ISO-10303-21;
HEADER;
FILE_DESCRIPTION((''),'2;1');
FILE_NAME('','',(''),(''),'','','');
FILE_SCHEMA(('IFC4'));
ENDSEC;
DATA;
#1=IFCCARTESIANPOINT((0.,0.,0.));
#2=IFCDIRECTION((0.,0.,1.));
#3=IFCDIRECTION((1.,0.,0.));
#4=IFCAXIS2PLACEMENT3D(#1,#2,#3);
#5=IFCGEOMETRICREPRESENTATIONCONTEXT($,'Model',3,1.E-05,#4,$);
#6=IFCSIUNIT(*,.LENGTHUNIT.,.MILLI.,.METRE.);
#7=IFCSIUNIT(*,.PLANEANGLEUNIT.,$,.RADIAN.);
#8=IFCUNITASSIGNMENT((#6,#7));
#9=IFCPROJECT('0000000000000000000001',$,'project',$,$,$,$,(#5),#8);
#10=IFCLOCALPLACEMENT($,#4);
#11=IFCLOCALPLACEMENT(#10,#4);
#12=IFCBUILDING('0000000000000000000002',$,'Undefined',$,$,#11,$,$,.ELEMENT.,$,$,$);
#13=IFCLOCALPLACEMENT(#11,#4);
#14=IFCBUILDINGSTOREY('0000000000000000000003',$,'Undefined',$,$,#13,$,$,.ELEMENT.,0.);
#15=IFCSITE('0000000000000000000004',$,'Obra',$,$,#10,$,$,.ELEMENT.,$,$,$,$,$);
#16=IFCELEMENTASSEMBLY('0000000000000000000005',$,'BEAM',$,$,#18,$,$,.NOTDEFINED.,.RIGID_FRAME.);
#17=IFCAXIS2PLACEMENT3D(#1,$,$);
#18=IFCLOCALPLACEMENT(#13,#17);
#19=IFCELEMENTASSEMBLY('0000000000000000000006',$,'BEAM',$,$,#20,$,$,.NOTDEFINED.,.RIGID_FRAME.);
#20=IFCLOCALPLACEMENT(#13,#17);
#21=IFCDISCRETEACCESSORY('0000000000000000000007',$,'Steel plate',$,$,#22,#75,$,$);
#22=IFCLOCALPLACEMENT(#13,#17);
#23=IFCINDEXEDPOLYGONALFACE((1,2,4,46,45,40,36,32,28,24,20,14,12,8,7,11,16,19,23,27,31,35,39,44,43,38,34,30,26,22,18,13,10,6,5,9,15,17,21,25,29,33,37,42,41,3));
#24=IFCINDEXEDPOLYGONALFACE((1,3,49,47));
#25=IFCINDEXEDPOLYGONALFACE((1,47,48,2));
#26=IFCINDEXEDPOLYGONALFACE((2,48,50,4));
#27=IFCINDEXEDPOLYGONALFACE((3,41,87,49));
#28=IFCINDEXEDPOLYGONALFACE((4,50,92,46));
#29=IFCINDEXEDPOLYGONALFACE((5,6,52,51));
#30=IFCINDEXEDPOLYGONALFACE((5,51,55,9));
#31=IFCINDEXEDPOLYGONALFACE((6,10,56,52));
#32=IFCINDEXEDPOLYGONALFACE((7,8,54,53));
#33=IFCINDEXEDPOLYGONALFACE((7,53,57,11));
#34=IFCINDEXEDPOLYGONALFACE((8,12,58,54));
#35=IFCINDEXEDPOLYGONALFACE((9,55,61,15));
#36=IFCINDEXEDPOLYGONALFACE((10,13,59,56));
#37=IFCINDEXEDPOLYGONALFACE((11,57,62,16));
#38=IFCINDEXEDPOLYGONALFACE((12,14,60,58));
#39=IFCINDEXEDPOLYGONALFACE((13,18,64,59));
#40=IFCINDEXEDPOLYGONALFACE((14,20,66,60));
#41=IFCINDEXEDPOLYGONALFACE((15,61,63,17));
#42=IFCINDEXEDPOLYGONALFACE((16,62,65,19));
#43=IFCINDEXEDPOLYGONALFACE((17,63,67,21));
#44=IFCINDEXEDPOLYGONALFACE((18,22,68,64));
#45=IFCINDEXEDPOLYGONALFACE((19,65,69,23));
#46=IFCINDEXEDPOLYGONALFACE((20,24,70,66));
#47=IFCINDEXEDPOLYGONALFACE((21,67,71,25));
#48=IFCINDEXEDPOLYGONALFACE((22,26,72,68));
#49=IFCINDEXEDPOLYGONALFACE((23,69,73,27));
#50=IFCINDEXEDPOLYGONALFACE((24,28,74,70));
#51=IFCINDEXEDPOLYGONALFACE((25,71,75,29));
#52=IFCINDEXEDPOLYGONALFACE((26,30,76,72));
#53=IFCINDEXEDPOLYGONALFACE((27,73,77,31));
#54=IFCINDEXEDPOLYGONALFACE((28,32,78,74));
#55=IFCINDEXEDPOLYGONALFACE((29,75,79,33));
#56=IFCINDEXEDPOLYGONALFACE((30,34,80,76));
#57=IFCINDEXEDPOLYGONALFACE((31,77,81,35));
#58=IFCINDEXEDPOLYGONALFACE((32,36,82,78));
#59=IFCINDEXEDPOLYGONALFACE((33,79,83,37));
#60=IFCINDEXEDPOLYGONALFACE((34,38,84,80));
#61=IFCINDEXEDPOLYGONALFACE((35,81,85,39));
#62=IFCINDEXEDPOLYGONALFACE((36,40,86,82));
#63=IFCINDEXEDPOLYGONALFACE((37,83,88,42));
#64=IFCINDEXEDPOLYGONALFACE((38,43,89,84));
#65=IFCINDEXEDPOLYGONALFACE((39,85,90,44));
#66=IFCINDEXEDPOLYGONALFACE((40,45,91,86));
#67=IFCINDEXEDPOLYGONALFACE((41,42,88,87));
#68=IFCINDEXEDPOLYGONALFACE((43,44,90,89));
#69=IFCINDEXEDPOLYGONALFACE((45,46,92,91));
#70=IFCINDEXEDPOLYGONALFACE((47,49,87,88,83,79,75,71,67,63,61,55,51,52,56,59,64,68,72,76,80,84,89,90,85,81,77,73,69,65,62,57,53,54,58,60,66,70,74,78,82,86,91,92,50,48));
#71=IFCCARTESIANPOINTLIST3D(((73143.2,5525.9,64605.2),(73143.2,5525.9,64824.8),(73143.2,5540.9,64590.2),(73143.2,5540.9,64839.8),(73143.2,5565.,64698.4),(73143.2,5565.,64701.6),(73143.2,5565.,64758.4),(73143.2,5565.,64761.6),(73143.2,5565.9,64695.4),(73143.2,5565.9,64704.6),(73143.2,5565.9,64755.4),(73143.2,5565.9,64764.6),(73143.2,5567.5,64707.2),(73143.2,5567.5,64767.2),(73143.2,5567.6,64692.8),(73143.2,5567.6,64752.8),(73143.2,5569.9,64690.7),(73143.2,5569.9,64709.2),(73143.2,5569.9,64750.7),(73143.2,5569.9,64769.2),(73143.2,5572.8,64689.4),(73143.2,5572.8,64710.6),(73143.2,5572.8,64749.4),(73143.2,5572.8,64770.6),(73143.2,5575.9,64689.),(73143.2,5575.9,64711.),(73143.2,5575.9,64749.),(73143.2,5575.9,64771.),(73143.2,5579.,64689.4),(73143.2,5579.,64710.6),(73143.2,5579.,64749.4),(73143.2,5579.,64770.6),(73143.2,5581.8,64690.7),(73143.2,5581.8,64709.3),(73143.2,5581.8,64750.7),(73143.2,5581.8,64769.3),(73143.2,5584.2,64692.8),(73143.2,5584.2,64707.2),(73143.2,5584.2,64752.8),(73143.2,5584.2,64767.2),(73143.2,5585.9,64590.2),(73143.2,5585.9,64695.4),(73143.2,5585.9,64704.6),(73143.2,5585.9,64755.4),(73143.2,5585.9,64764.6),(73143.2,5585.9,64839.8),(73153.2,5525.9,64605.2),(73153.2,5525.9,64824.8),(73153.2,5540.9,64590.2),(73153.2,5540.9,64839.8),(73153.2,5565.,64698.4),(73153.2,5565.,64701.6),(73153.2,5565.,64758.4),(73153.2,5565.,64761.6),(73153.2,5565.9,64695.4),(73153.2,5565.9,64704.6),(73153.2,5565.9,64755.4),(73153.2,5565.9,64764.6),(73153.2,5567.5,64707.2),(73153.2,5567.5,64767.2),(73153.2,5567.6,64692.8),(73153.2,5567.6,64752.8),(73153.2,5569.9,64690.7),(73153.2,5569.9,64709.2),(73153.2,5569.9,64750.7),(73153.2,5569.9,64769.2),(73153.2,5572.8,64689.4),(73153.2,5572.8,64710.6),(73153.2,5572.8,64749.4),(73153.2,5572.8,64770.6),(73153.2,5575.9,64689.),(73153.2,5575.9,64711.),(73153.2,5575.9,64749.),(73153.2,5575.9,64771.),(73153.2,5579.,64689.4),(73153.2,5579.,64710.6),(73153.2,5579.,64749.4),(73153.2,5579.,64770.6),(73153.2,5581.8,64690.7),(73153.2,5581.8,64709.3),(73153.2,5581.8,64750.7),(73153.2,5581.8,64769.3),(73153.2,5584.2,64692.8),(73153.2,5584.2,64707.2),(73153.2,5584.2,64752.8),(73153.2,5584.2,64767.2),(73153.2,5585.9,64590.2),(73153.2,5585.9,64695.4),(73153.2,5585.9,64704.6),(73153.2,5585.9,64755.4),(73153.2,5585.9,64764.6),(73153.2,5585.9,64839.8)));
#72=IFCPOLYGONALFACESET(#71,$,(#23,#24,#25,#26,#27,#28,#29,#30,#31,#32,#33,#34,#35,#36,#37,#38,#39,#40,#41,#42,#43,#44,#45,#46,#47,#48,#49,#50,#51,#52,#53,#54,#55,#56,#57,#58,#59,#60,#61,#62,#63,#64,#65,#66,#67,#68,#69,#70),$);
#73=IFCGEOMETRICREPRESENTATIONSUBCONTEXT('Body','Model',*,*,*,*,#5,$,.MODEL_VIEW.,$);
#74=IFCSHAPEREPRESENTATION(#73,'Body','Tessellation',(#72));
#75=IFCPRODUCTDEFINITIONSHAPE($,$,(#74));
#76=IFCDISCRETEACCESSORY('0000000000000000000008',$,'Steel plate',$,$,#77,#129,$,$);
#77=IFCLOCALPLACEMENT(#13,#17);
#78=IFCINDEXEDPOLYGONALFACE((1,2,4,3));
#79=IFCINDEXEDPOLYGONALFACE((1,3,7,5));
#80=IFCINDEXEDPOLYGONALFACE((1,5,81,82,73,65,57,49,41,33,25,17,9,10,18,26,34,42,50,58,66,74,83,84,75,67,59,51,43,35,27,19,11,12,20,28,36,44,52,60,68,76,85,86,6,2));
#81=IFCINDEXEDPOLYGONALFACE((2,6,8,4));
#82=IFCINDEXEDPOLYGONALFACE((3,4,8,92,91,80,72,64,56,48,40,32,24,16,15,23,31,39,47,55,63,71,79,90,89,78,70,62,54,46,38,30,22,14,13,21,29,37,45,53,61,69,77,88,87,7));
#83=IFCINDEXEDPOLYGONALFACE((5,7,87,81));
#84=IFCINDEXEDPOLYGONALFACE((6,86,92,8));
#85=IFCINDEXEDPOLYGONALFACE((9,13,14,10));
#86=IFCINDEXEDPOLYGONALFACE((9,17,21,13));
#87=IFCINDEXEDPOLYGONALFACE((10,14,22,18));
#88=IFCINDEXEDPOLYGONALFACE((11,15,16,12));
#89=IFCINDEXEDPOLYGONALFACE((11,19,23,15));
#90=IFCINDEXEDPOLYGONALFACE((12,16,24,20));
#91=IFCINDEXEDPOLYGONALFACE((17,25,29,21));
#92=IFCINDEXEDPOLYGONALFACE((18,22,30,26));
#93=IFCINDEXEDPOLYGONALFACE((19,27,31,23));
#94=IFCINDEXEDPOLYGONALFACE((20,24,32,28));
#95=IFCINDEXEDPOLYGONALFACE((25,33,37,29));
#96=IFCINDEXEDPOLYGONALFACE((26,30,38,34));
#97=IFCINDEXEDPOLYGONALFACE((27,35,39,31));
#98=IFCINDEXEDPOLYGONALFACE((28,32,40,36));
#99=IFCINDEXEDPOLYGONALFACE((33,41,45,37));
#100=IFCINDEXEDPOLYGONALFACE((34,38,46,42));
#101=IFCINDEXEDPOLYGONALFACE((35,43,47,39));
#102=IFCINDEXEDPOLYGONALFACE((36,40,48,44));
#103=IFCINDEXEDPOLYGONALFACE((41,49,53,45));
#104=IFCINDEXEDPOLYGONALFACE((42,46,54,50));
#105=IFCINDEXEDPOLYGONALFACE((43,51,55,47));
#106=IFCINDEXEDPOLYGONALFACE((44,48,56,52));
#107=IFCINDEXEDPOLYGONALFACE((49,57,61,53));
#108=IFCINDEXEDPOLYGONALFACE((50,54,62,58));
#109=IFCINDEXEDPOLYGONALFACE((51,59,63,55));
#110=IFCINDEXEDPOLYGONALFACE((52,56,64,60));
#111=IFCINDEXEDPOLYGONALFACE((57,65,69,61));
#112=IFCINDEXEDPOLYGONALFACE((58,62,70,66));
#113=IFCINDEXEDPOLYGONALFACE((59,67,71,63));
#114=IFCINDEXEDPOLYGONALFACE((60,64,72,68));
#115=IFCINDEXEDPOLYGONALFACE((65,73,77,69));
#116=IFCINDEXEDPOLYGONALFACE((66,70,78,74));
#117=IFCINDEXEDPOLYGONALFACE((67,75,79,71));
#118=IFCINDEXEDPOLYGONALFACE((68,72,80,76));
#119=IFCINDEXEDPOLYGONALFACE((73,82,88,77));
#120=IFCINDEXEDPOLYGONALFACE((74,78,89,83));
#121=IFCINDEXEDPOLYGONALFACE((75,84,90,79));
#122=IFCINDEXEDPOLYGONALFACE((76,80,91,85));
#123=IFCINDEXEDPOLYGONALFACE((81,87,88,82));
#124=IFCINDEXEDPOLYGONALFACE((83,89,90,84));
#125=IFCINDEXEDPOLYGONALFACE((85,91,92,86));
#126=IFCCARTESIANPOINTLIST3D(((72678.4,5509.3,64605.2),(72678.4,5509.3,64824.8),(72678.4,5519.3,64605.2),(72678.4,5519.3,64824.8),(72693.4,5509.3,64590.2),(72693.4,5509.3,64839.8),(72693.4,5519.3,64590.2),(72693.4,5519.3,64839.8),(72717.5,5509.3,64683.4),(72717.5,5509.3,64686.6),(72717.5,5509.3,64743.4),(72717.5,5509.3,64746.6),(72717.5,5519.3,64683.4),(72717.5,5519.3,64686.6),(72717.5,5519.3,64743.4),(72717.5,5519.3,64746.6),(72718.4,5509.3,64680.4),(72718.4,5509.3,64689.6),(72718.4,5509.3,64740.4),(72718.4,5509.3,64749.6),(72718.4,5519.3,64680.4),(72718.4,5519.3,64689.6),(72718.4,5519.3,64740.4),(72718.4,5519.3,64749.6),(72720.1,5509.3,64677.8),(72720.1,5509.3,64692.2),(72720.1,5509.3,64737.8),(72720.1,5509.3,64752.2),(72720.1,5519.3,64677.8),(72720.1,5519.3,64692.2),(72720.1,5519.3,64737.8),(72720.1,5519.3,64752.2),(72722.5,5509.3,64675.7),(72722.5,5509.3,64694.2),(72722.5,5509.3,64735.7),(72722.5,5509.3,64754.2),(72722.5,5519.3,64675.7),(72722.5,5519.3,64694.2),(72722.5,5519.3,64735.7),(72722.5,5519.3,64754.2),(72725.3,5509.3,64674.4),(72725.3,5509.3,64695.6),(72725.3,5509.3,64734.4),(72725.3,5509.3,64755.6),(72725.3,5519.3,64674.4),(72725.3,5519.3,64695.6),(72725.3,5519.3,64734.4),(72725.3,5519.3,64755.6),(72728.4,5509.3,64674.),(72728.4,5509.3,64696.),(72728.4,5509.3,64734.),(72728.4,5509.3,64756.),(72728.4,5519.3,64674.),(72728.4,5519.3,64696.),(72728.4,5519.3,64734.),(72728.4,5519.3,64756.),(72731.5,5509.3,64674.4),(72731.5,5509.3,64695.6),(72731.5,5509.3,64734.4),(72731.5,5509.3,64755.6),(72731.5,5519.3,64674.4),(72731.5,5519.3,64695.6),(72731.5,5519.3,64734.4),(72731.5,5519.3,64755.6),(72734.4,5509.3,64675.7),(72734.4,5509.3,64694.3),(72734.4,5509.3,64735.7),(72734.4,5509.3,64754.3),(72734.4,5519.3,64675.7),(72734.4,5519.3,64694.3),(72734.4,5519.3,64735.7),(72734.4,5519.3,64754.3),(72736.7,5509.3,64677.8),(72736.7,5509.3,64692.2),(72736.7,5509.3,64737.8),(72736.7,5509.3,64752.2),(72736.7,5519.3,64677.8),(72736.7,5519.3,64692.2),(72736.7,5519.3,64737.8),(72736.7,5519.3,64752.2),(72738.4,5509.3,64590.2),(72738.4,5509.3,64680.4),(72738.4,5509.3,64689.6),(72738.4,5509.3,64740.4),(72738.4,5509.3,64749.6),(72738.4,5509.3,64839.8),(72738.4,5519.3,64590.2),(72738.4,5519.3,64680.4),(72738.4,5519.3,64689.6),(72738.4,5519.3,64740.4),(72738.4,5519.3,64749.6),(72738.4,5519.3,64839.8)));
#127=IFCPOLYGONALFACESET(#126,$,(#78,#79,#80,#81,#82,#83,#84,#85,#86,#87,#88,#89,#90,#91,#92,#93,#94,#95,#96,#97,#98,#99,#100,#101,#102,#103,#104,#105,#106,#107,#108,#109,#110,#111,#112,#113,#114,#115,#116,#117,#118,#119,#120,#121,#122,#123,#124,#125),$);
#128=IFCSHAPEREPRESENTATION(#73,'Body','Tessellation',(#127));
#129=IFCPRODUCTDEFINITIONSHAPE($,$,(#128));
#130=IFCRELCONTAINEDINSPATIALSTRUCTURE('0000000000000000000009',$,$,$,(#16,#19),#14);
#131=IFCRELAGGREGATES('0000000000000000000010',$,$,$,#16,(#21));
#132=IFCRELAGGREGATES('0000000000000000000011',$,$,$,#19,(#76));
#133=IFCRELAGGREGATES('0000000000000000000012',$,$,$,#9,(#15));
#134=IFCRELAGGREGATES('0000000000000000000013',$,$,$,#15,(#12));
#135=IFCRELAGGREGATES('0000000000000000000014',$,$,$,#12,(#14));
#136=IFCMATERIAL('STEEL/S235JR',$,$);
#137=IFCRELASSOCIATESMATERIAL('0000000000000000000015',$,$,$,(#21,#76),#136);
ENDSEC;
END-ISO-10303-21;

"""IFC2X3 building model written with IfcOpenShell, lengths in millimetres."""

from ifc_helpers import new_model, si_unit, frame, origin_with_axes, origin_2d_with_axis, place, context, subcontext, project, spatial, polyline, circle, outline, extrude, source, transform, mapped, material, element, aggregate, save


model = new_model("IFC2X3")

# Units and contexts
model_context = context("Model", 3, precision=1e-05, world=origin_with_axes())
body_context = subcontext(model_context, "Body", "Model", "MODEL_VIEW")
ifc_project = project(units=[si_unit("LENGTHUNIT", "METRE", prefix="MILLI"), si_unit("PLANEANGLEUNIT", "RADIAN")], contexts=[model_context])

# Site, building, storey
site_placement = place(None, origin_with_axes())
site = spatial("IfcSite", under=ifc_project, at=site_placement, Name="Obra", CompositionType="ELEMENT")
building_placement = place(site_placement, origin_with_axes())
building = spatial("IfcBuilding", under=site, at=building_placement, Name="Undefined", CompositionType="ELEMENT")
storey_placement = place(building_placement, origin_with_axes())
storey = spatial("IfcBuildingStorey", under=building, at=storey_placement, Name="Undefined", CompositionType="ELEMENT", Elevation=0.0)

# Element assemblies
ifc_material_1 = material(Name="STEEL/S235JR")
assembly_1_placement = place(storey_placement, origin_with_axes())
assembly_1 = element("IfcElementAssembly", 1, at=assembly_1_placement, inside=storey, Name="BEAM", AssemblyPlace="NOTDEFINED", PredefinedType="RIGID_FRAME")
assembly_2_placement = place(storey_placement, origin_with_axes())
assembly_2 = element("IfcElementAssembly", 2, at=assembly_2_placement, inside=storey, Name="BEAM", AssemblyPlace="NOTDEFINED", PredefinedType="RIGID_FRAME")

# Discrete accessories, openings
discrete_accessory_1_placement = place(assembly_1_placement, frame((73148.2, 5585.9, 64590.2), z_axis=(-1.0, 0.0, 0.0), x_axis=(0.0, -1.0, 0.0)))
discrete_accessory_1 = element("IfcDiscreteAccessory", 3, at=discrete_accessory_1_placement, material=ifc_material_1, Name="Steel plate", context=body_context, shape_type="SweptSolid", body=[
    extrude(outline(polyline([(0.0, 0.0), (45.0, 0.0), (60.0, 15.0), (60.0, 234.6), (45.0, 249.6), (0.0, 249.6), (0.0, 0.0)])), frame((0.0, 0.0, -5.0), z_axis=(0.0, 0.0, 1.0), x_axis=(1.0, 0.0, 0.0)), (0.0, 0.0, 1.0), 10.0),
])
shared_shape_1 = source(origin_with_axes(), body_context, "Body", "SweptSolid", [
    extrude(circle(Radius=11.0, at=origin_2d_with_axis()), frame((0.0, -13.2, 0.0), z_axis=(0.0, 1.0, 0.0), x_axis=(1.0, 0.0, 0.0)), (0.0, 0.0, 1.0), 10.2),
])
opening_1_placement = place(assembly_1_placement, frame((73140.1, 5535.9, 64850.0), z_axis=(0.0, 1.0, 0.0), x_axis=(0.0, 0.0, -1.0)))
element("IfcOpeningElement", 4, at=opening_1_placement, cuts=discrete_accessory_1, ObjectType="Opening", context=body_context, shape_type="MappedRepresentation", body=[
    mapped(shared_shape_1, transform((90.0, 0.0, 40.0))),
    mapped(shared_shape_1, transform((150.0, 0.0, 40.0))),
])
aggregate(assembly_1, [discrete_accessory_1])
discrete_accessory_2_placement = place(assembly_2_placement, frame((72738.4, 5514.3, 64590.2), z_axis=(0.0, 1.0, 0.0), x_axis=(-1.0, 0.0, 0.0)))
discrete_accessory_2 = element("IfcDiscreteAccessory", 5, at=discrete_accessory_2_placement, material=ifc_material_1, Name="Steel plate", context=body_context, shape_type="SweptSolid", body=[
    extrude(outline(polyline([(0.0, 0.0), (45.0, 0.0), (60.0, 15.0), (60.0, 234.6), (45.0, 249.6), (0.0, 249.6), (0.0, 0.0)])), frame((0.0, 0.0, -5.0), z_axis=(0.0, 0.0, 1.0), x_axis=(1.0, 0.0, 0.0)), (0.0, 0.0, 1.0), 10.0),
])
shared_shape_2 = source(origin_with_axes(), body_context, "Body", "SweptSolid", [
    extrude(circle(Radius=11.0, at=origin_2d_with_axis()), frame((0.0, -13.4, 0.0), z_axis=(0.0, 1.0, 0.0), x_axis=(1.0, 0.0, 0.0)), (0.0, 0.0, 1.0), 10.2),
])
opening_2_placement = place(assembly_2_placement, frame((72688.4, 5522.6, 64850.0), z_axis=(1.0, 0.0, 0.0), x_axis=(0.0, 0.0, -1.0)))
element("IfcOpeningElement", 6, at=opening_2_placement, cuts=discrete_accessory_2, ObjectType="Opening", context=body_context, shape_type="MappedRepresentation", body=[
    mapped(shared_shape_2, transform((105.0, 0.0, 40.0))),
    mapped(shared_shape_2, transform((165.0, 0.0, 40.0))),
])
aggregate(assembly_2, [discrete_accessory_2])

save(model, "model.ifc")
